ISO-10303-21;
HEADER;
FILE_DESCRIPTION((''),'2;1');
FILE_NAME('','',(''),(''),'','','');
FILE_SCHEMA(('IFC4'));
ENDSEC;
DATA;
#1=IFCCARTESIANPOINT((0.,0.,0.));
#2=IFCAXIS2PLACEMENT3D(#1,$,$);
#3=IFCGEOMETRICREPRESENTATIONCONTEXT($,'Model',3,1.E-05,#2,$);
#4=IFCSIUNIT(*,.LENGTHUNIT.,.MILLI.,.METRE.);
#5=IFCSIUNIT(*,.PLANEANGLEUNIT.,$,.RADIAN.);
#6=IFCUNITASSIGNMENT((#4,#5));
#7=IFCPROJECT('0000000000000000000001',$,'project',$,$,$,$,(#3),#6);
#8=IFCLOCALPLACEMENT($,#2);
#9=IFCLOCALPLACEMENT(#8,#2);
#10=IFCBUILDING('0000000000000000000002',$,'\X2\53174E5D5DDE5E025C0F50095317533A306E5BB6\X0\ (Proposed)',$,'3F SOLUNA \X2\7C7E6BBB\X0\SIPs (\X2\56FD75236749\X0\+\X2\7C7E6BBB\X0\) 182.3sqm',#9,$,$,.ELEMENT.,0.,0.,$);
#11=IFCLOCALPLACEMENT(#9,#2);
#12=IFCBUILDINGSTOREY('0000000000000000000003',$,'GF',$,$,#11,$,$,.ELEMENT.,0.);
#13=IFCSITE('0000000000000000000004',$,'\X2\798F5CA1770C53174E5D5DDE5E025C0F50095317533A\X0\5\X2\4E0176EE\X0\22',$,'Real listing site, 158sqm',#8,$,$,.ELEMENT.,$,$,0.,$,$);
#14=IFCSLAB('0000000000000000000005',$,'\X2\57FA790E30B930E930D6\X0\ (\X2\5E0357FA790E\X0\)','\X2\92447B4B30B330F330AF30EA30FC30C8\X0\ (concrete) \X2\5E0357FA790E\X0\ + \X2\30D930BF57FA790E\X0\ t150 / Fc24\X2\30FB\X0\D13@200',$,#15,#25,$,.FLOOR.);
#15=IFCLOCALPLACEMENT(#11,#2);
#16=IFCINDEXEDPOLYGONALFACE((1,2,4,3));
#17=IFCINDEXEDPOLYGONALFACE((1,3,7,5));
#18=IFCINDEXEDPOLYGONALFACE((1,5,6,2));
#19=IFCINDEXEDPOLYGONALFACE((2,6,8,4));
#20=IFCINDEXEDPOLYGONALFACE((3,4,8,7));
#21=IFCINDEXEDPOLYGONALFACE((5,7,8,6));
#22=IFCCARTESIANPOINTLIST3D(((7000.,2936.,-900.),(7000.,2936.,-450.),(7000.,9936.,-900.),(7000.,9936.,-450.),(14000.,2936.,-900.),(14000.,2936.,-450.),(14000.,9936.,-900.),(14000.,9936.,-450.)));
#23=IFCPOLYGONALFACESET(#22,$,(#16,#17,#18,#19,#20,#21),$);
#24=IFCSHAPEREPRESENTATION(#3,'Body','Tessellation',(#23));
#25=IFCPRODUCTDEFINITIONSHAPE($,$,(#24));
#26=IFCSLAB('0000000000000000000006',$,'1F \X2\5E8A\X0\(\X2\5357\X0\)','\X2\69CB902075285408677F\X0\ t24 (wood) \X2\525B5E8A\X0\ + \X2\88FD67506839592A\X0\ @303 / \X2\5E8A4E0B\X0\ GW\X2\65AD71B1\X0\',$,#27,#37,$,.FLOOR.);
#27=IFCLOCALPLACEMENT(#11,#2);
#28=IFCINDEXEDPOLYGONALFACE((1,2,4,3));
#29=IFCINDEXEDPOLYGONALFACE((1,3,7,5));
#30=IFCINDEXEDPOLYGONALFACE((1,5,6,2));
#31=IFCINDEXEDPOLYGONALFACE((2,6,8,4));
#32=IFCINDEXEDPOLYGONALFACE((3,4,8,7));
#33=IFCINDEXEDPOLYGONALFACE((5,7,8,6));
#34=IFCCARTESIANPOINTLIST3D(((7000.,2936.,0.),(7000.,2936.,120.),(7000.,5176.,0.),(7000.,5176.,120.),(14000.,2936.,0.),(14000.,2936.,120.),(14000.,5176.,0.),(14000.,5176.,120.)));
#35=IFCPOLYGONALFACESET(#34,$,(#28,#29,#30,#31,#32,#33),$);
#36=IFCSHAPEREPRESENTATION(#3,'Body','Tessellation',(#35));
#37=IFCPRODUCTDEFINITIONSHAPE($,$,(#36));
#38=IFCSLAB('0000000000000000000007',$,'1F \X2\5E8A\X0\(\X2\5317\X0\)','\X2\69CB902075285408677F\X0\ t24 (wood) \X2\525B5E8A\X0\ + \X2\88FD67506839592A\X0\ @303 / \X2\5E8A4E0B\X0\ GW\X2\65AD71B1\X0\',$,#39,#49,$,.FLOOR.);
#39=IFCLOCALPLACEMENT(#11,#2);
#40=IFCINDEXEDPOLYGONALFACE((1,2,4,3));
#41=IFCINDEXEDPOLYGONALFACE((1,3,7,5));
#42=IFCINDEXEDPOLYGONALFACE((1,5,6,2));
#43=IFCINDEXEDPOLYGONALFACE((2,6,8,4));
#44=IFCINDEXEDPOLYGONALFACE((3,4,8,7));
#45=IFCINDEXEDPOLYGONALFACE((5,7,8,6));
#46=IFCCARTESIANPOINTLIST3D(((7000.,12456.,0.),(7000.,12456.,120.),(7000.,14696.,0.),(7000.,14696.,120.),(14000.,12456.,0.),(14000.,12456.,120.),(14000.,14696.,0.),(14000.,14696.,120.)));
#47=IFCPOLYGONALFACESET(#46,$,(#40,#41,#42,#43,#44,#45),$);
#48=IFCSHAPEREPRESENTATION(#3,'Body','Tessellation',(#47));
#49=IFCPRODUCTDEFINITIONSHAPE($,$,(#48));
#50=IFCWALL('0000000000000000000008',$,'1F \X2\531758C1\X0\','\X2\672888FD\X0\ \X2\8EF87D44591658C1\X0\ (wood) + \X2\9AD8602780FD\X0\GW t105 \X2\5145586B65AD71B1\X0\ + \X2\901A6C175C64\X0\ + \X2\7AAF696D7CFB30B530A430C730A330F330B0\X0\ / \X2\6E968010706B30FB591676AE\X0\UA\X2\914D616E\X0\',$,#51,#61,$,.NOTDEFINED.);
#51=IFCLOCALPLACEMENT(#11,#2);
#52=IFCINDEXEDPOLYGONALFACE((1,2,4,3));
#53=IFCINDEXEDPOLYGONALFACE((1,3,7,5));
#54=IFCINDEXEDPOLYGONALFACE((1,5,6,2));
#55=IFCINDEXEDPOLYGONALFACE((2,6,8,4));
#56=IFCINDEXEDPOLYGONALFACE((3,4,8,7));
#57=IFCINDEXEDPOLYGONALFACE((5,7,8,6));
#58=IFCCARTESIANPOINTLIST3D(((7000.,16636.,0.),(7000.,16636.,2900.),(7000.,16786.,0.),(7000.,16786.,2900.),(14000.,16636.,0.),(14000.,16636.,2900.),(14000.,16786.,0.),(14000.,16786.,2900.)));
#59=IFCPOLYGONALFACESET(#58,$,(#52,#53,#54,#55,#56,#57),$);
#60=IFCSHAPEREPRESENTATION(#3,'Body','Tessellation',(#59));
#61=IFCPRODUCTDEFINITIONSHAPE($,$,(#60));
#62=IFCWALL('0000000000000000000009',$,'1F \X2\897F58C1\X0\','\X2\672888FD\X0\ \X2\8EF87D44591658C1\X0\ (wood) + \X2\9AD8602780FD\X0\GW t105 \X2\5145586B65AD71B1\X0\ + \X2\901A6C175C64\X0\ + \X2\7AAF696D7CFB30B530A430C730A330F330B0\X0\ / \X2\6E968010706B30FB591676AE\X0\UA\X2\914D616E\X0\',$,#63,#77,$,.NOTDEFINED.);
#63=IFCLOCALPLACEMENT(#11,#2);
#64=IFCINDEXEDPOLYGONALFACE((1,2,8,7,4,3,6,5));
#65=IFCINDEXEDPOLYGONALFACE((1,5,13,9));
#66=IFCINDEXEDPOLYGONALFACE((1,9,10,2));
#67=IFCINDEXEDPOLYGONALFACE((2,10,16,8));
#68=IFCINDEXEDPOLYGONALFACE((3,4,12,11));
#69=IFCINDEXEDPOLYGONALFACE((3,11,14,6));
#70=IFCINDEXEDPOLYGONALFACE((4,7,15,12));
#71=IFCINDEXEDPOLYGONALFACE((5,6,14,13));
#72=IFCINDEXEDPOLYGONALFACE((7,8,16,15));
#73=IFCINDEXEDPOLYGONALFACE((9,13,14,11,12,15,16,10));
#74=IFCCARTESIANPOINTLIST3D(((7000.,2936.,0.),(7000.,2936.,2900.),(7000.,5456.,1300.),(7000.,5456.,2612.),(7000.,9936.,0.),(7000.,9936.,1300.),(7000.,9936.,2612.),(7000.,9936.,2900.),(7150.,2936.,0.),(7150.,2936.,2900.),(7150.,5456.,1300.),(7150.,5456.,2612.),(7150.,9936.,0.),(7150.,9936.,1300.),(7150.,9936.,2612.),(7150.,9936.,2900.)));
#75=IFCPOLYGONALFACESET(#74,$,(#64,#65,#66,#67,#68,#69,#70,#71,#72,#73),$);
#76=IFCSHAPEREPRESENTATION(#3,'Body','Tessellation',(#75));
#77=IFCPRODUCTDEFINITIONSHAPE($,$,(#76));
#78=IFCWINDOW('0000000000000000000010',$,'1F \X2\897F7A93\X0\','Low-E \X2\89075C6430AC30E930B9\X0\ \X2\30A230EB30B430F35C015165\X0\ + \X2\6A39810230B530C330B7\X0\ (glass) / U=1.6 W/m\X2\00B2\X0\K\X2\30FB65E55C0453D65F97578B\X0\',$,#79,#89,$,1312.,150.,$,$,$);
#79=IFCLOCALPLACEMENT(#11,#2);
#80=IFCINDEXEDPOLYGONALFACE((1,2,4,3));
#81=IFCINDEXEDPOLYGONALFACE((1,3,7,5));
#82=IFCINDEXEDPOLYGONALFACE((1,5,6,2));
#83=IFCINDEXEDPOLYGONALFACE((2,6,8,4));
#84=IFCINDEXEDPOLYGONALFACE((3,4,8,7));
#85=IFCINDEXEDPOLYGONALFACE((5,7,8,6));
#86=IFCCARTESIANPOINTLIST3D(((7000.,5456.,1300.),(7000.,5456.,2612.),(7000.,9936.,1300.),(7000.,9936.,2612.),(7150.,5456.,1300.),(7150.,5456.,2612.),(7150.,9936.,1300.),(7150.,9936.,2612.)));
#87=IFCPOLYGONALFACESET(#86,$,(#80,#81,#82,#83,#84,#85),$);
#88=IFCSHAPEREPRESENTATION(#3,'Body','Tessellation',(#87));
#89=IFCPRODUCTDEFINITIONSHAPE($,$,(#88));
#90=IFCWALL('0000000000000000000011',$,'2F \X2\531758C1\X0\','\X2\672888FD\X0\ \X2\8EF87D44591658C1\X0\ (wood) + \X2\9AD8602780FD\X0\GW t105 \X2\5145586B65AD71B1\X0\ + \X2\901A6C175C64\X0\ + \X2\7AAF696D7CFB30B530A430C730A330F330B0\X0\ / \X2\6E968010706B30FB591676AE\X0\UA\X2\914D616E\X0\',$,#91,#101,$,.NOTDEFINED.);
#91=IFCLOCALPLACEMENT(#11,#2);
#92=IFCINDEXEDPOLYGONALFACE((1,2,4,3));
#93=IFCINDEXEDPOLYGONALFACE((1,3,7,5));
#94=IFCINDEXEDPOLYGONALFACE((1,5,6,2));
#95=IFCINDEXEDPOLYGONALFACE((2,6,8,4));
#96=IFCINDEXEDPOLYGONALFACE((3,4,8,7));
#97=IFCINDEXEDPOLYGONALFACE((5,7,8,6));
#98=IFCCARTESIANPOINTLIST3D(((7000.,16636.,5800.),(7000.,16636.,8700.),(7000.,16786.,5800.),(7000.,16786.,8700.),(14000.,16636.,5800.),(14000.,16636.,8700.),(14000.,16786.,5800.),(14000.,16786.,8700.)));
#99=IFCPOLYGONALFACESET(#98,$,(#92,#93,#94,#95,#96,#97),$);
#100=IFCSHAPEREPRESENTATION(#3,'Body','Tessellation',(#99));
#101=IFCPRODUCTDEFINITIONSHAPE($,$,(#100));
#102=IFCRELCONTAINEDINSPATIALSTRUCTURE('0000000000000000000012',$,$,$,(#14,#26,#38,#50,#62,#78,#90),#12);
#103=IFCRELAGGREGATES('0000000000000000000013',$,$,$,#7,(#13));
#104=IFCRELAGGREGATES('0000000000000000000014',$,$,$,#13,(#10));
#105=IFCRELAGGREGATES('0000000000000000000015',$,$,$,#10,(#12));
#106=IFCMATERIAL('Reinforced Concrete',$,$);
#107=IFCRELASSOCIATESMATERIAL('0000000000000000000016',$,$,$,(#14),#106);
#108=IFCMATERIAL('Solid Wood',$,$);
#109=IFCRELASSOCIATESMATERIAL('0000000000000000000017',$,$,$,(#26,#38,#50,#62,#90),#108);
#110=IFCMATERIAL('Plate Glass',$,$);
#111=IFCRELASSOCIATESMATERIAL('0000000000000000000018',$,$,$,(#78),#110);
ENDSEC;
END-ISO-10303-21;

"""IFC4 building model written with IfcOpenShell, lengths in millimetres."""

from ifc_helpers import new_model, si_unit, frame, frame_2d, origin, place, context, project, spatial, rectangle, extrude, material, element, fill, save


model = new_model("IFC4")

# Units and contexts
model_context = context("Model", 3, precision=1e-05, world=origin())
ifc_project = project(units=[si_unit("LENGTHUNIT", "METRE", prefix="MILLI"), si_unit("PLANEANGLEUNIT", "RADIAN")], contexts=[model_context])

# Site, building, storey
site_placement = place(None, origin())
site = spatial("IfcSite", under=ifc_project, at=site_placement, Name="福岡県北九州市小倉北区5丁目22", ObjectType="Real listing site, 158sqm", CompositionType="ELEMENT", RefElevation=0.0)
building_placement = place(site_placement, origin())
building = spatial("IfcBuilding", under=site, at=building_placement, Name="北九州市小倉北区の家 (Proposed)", ObjectType="3F SOLUNA 籾殻SIPs (国産杉+籾殻) 182.3sqm", CompositionType="ELEMENT", ElevationOfRefHeight=0.0, ElevationOfTerrain=0.0)
storey_placement = place(building_placement, origin())
storey = spatial("IfcBuildingStorey", under=building, at=storey_placement, Name="GF", CompositionType="ELEMENT", Elevation=0.0)

# Slabs
ifc_material_1 = material(Name="Reinforced Concrete")
slab_1_placement = place(storey_placement, frame((3500.0, 1468.0, -450.0)))
element("IfcSlab", 1, at=slab_1_placement, inside=storey, material=ifc_material_1, Name="基礎スラブ (布基礎)", Description="鉄筋コンクリート (concrete) 布基礎 + ベタ基礎 t150 / Fc24・D13@200", PredefinedType="FLOOR", context=model_context, shape_type="SweptSolid", body=[
    extrude(rectangle(XDim=7000.0, YDim=7000.0, at=frame_2d((3500.0, 3500.0))), frame((3500.0, 1468.0, -450.0)), (0.0, 0.0, 1.0), 450.0),
])
ifc_material_2 = material(Name="Solid Wood")
slab_2_placement = place(storey_placement, frame((3500.0, 1468.0, 0.0)))
element("IfcSlab", 2, at=slab_2_placement, inside=storey, material=ifc_material_2, Name="1F 床(南)", Description="構造用合板 t24 (wood) 剛床 + 製材根太 @303 / 床下 GW断熱", PredefinedType="FLOOR", context=model_context, shape_type="SweptSolid", body=[
    extrude(rectangle(XDim=7000.0, YDim=2240.0, at=frame_2d((3500.0, 1120.0))), frame((3500.0, 1468.0, 0.0)), (0.0, 0.0, 1.0), 120.0),
])
slab_3_placement = place(storey_placement, frame((3500.0, 6228.0, 0.0)))
element("IfcSlab", 3, at=slab_3_placement, inside=storey, material=ifc_material_2, Name="1F 床(北)", Description="構造用合板 t24 (wood) 剛床 + 製材根太 @303 / 床下 GW断熱", PredefinedType="FLOOR", context=model_context, shape_type="SweptSolid", body=[
    extrude(rectangle(XDim=7000.0, YDim=2240.0, at=frame_2d((3500.0, 1120.0))), frame((3500.0, 6228.0, 0.0)), (0.0, 0.0, 1.0), 120.0),
])

# Shared definitions
ifc_material_3 = material(Name="Plate Glass")

# Wall
wall_1_placement = place(storey_placement, frame((3500.0, 8318.0, 0.0)))
element("IfcWall", 4, at=wall_1_placement, inside=storey, material=ifc_material_2, Name="1F 北壁", Description="木製 軸組外壁 (wood) + 高性能GW t105 充填断熱 + 通気層 + 窯業系サイディング / 準耐火・外皮UA配慮", PredefinedType="NOTDEFINED", context=model_context, shape_type="SweptSolid", body=[
    extrude(rectangle(XDim=7000.0, YDim=150.0, at=frame_2d((3500.0, 75.0))), frame((3500.0, 8318.0, 0.0)), (0.0, 0.0, 1.0), 2900.0),
])

# Wall, opening, window
wall_2_placement = place(storey_placement, frame((3500.0, 1468.0, 0.0)))
wall_2 = element("IfcWall", 5, at=wall_2_placement, inside=storey, material=ifc_material_2, Name="1F 西壁", Description="木製 軸組外壁 (wood) + 高性能GW t105 充填断熱 + 通気層 + 窯業系サイディング / 準耐火・外皮UA配慮", PredefinedType="NOTDEFINED", context=model_context, shape_type="SweptSolid", body=[
    extrude(rectangle(XDim=150.0, YDim=7000.0, at=frame_2d((75.0, 3500.0))), frame((3500.0, 1468.0, 0.0)), (0.0, 0.0, 1.0), 2900.0),
])
opening_1_placement = place(storey_placement, frame((3500.0, 2728.0, 650.0)))
opening_1 = element("IfcOpeningElement", 6, at=opening_1_placement, cuts=wall_2, PredefinedType="NOTDEFINED", context=model_context, shape_type="SweptSolid", body=[
    extrude(rectangle(XDim=150.0, YDim=4480.0, at=frame_2d((75.0, 2240.0))), frame((3500.0, 2728.0, 650.0)), (0.0, 0.0, 1.0), 1312.0),
])
window_1_placement = place(storey_placement, frame((3500.0, 2728.0, 650.0)))
window_1 = element("IfcWindow", 7, at=window_1_placement, inside=storey, material=ifc_material_3, Name="1F 西窓", Description="Low-E 複層ガラス アルゴン封入 + 樹脂サッシ (glass) / U=1.6 W/m²K・日射取得型", OverallHeight=1312.0, OverallWidth=150.0, context=model_context, shape_type="SweptSolid", body=[
    extrude(rectangle(XDim=150.0, YDim=4480.0, at=frame_2d((75.0, 2240.0))), frame((3500.0, 2728.0, 650.0)), (0.0, 0.0, 1.0), 1312.0),
])
fill(opening_1, window_1)

# Wall
wall_3_placement = place(storey_placement, frame((3500.0, 8318.0, 2900.0)))
element("IfcWall", 8, at=wall_3_placement, inside=storey, material=ifc_material_2, Name="2F 北壁", Description="木製 軸組外壁 (wood) + 高性能GW t105 充填断熱 + 通気層 + 窯業系サイディング / 準耐火・外皮UA配慮", PredefinedType="NOTDEFINED", context=model_context, shape_type="SweptSolid", body=[
    extrude(rectangle(XDim=7000.0, YDim=150.0, at=frame_2d((3500.0, 75.0))), frame((3500.0, 8318.0, 2900.0)), (0.0, 0.0, 1.0), 2900.0),
])

save(model, "model.ifc")
